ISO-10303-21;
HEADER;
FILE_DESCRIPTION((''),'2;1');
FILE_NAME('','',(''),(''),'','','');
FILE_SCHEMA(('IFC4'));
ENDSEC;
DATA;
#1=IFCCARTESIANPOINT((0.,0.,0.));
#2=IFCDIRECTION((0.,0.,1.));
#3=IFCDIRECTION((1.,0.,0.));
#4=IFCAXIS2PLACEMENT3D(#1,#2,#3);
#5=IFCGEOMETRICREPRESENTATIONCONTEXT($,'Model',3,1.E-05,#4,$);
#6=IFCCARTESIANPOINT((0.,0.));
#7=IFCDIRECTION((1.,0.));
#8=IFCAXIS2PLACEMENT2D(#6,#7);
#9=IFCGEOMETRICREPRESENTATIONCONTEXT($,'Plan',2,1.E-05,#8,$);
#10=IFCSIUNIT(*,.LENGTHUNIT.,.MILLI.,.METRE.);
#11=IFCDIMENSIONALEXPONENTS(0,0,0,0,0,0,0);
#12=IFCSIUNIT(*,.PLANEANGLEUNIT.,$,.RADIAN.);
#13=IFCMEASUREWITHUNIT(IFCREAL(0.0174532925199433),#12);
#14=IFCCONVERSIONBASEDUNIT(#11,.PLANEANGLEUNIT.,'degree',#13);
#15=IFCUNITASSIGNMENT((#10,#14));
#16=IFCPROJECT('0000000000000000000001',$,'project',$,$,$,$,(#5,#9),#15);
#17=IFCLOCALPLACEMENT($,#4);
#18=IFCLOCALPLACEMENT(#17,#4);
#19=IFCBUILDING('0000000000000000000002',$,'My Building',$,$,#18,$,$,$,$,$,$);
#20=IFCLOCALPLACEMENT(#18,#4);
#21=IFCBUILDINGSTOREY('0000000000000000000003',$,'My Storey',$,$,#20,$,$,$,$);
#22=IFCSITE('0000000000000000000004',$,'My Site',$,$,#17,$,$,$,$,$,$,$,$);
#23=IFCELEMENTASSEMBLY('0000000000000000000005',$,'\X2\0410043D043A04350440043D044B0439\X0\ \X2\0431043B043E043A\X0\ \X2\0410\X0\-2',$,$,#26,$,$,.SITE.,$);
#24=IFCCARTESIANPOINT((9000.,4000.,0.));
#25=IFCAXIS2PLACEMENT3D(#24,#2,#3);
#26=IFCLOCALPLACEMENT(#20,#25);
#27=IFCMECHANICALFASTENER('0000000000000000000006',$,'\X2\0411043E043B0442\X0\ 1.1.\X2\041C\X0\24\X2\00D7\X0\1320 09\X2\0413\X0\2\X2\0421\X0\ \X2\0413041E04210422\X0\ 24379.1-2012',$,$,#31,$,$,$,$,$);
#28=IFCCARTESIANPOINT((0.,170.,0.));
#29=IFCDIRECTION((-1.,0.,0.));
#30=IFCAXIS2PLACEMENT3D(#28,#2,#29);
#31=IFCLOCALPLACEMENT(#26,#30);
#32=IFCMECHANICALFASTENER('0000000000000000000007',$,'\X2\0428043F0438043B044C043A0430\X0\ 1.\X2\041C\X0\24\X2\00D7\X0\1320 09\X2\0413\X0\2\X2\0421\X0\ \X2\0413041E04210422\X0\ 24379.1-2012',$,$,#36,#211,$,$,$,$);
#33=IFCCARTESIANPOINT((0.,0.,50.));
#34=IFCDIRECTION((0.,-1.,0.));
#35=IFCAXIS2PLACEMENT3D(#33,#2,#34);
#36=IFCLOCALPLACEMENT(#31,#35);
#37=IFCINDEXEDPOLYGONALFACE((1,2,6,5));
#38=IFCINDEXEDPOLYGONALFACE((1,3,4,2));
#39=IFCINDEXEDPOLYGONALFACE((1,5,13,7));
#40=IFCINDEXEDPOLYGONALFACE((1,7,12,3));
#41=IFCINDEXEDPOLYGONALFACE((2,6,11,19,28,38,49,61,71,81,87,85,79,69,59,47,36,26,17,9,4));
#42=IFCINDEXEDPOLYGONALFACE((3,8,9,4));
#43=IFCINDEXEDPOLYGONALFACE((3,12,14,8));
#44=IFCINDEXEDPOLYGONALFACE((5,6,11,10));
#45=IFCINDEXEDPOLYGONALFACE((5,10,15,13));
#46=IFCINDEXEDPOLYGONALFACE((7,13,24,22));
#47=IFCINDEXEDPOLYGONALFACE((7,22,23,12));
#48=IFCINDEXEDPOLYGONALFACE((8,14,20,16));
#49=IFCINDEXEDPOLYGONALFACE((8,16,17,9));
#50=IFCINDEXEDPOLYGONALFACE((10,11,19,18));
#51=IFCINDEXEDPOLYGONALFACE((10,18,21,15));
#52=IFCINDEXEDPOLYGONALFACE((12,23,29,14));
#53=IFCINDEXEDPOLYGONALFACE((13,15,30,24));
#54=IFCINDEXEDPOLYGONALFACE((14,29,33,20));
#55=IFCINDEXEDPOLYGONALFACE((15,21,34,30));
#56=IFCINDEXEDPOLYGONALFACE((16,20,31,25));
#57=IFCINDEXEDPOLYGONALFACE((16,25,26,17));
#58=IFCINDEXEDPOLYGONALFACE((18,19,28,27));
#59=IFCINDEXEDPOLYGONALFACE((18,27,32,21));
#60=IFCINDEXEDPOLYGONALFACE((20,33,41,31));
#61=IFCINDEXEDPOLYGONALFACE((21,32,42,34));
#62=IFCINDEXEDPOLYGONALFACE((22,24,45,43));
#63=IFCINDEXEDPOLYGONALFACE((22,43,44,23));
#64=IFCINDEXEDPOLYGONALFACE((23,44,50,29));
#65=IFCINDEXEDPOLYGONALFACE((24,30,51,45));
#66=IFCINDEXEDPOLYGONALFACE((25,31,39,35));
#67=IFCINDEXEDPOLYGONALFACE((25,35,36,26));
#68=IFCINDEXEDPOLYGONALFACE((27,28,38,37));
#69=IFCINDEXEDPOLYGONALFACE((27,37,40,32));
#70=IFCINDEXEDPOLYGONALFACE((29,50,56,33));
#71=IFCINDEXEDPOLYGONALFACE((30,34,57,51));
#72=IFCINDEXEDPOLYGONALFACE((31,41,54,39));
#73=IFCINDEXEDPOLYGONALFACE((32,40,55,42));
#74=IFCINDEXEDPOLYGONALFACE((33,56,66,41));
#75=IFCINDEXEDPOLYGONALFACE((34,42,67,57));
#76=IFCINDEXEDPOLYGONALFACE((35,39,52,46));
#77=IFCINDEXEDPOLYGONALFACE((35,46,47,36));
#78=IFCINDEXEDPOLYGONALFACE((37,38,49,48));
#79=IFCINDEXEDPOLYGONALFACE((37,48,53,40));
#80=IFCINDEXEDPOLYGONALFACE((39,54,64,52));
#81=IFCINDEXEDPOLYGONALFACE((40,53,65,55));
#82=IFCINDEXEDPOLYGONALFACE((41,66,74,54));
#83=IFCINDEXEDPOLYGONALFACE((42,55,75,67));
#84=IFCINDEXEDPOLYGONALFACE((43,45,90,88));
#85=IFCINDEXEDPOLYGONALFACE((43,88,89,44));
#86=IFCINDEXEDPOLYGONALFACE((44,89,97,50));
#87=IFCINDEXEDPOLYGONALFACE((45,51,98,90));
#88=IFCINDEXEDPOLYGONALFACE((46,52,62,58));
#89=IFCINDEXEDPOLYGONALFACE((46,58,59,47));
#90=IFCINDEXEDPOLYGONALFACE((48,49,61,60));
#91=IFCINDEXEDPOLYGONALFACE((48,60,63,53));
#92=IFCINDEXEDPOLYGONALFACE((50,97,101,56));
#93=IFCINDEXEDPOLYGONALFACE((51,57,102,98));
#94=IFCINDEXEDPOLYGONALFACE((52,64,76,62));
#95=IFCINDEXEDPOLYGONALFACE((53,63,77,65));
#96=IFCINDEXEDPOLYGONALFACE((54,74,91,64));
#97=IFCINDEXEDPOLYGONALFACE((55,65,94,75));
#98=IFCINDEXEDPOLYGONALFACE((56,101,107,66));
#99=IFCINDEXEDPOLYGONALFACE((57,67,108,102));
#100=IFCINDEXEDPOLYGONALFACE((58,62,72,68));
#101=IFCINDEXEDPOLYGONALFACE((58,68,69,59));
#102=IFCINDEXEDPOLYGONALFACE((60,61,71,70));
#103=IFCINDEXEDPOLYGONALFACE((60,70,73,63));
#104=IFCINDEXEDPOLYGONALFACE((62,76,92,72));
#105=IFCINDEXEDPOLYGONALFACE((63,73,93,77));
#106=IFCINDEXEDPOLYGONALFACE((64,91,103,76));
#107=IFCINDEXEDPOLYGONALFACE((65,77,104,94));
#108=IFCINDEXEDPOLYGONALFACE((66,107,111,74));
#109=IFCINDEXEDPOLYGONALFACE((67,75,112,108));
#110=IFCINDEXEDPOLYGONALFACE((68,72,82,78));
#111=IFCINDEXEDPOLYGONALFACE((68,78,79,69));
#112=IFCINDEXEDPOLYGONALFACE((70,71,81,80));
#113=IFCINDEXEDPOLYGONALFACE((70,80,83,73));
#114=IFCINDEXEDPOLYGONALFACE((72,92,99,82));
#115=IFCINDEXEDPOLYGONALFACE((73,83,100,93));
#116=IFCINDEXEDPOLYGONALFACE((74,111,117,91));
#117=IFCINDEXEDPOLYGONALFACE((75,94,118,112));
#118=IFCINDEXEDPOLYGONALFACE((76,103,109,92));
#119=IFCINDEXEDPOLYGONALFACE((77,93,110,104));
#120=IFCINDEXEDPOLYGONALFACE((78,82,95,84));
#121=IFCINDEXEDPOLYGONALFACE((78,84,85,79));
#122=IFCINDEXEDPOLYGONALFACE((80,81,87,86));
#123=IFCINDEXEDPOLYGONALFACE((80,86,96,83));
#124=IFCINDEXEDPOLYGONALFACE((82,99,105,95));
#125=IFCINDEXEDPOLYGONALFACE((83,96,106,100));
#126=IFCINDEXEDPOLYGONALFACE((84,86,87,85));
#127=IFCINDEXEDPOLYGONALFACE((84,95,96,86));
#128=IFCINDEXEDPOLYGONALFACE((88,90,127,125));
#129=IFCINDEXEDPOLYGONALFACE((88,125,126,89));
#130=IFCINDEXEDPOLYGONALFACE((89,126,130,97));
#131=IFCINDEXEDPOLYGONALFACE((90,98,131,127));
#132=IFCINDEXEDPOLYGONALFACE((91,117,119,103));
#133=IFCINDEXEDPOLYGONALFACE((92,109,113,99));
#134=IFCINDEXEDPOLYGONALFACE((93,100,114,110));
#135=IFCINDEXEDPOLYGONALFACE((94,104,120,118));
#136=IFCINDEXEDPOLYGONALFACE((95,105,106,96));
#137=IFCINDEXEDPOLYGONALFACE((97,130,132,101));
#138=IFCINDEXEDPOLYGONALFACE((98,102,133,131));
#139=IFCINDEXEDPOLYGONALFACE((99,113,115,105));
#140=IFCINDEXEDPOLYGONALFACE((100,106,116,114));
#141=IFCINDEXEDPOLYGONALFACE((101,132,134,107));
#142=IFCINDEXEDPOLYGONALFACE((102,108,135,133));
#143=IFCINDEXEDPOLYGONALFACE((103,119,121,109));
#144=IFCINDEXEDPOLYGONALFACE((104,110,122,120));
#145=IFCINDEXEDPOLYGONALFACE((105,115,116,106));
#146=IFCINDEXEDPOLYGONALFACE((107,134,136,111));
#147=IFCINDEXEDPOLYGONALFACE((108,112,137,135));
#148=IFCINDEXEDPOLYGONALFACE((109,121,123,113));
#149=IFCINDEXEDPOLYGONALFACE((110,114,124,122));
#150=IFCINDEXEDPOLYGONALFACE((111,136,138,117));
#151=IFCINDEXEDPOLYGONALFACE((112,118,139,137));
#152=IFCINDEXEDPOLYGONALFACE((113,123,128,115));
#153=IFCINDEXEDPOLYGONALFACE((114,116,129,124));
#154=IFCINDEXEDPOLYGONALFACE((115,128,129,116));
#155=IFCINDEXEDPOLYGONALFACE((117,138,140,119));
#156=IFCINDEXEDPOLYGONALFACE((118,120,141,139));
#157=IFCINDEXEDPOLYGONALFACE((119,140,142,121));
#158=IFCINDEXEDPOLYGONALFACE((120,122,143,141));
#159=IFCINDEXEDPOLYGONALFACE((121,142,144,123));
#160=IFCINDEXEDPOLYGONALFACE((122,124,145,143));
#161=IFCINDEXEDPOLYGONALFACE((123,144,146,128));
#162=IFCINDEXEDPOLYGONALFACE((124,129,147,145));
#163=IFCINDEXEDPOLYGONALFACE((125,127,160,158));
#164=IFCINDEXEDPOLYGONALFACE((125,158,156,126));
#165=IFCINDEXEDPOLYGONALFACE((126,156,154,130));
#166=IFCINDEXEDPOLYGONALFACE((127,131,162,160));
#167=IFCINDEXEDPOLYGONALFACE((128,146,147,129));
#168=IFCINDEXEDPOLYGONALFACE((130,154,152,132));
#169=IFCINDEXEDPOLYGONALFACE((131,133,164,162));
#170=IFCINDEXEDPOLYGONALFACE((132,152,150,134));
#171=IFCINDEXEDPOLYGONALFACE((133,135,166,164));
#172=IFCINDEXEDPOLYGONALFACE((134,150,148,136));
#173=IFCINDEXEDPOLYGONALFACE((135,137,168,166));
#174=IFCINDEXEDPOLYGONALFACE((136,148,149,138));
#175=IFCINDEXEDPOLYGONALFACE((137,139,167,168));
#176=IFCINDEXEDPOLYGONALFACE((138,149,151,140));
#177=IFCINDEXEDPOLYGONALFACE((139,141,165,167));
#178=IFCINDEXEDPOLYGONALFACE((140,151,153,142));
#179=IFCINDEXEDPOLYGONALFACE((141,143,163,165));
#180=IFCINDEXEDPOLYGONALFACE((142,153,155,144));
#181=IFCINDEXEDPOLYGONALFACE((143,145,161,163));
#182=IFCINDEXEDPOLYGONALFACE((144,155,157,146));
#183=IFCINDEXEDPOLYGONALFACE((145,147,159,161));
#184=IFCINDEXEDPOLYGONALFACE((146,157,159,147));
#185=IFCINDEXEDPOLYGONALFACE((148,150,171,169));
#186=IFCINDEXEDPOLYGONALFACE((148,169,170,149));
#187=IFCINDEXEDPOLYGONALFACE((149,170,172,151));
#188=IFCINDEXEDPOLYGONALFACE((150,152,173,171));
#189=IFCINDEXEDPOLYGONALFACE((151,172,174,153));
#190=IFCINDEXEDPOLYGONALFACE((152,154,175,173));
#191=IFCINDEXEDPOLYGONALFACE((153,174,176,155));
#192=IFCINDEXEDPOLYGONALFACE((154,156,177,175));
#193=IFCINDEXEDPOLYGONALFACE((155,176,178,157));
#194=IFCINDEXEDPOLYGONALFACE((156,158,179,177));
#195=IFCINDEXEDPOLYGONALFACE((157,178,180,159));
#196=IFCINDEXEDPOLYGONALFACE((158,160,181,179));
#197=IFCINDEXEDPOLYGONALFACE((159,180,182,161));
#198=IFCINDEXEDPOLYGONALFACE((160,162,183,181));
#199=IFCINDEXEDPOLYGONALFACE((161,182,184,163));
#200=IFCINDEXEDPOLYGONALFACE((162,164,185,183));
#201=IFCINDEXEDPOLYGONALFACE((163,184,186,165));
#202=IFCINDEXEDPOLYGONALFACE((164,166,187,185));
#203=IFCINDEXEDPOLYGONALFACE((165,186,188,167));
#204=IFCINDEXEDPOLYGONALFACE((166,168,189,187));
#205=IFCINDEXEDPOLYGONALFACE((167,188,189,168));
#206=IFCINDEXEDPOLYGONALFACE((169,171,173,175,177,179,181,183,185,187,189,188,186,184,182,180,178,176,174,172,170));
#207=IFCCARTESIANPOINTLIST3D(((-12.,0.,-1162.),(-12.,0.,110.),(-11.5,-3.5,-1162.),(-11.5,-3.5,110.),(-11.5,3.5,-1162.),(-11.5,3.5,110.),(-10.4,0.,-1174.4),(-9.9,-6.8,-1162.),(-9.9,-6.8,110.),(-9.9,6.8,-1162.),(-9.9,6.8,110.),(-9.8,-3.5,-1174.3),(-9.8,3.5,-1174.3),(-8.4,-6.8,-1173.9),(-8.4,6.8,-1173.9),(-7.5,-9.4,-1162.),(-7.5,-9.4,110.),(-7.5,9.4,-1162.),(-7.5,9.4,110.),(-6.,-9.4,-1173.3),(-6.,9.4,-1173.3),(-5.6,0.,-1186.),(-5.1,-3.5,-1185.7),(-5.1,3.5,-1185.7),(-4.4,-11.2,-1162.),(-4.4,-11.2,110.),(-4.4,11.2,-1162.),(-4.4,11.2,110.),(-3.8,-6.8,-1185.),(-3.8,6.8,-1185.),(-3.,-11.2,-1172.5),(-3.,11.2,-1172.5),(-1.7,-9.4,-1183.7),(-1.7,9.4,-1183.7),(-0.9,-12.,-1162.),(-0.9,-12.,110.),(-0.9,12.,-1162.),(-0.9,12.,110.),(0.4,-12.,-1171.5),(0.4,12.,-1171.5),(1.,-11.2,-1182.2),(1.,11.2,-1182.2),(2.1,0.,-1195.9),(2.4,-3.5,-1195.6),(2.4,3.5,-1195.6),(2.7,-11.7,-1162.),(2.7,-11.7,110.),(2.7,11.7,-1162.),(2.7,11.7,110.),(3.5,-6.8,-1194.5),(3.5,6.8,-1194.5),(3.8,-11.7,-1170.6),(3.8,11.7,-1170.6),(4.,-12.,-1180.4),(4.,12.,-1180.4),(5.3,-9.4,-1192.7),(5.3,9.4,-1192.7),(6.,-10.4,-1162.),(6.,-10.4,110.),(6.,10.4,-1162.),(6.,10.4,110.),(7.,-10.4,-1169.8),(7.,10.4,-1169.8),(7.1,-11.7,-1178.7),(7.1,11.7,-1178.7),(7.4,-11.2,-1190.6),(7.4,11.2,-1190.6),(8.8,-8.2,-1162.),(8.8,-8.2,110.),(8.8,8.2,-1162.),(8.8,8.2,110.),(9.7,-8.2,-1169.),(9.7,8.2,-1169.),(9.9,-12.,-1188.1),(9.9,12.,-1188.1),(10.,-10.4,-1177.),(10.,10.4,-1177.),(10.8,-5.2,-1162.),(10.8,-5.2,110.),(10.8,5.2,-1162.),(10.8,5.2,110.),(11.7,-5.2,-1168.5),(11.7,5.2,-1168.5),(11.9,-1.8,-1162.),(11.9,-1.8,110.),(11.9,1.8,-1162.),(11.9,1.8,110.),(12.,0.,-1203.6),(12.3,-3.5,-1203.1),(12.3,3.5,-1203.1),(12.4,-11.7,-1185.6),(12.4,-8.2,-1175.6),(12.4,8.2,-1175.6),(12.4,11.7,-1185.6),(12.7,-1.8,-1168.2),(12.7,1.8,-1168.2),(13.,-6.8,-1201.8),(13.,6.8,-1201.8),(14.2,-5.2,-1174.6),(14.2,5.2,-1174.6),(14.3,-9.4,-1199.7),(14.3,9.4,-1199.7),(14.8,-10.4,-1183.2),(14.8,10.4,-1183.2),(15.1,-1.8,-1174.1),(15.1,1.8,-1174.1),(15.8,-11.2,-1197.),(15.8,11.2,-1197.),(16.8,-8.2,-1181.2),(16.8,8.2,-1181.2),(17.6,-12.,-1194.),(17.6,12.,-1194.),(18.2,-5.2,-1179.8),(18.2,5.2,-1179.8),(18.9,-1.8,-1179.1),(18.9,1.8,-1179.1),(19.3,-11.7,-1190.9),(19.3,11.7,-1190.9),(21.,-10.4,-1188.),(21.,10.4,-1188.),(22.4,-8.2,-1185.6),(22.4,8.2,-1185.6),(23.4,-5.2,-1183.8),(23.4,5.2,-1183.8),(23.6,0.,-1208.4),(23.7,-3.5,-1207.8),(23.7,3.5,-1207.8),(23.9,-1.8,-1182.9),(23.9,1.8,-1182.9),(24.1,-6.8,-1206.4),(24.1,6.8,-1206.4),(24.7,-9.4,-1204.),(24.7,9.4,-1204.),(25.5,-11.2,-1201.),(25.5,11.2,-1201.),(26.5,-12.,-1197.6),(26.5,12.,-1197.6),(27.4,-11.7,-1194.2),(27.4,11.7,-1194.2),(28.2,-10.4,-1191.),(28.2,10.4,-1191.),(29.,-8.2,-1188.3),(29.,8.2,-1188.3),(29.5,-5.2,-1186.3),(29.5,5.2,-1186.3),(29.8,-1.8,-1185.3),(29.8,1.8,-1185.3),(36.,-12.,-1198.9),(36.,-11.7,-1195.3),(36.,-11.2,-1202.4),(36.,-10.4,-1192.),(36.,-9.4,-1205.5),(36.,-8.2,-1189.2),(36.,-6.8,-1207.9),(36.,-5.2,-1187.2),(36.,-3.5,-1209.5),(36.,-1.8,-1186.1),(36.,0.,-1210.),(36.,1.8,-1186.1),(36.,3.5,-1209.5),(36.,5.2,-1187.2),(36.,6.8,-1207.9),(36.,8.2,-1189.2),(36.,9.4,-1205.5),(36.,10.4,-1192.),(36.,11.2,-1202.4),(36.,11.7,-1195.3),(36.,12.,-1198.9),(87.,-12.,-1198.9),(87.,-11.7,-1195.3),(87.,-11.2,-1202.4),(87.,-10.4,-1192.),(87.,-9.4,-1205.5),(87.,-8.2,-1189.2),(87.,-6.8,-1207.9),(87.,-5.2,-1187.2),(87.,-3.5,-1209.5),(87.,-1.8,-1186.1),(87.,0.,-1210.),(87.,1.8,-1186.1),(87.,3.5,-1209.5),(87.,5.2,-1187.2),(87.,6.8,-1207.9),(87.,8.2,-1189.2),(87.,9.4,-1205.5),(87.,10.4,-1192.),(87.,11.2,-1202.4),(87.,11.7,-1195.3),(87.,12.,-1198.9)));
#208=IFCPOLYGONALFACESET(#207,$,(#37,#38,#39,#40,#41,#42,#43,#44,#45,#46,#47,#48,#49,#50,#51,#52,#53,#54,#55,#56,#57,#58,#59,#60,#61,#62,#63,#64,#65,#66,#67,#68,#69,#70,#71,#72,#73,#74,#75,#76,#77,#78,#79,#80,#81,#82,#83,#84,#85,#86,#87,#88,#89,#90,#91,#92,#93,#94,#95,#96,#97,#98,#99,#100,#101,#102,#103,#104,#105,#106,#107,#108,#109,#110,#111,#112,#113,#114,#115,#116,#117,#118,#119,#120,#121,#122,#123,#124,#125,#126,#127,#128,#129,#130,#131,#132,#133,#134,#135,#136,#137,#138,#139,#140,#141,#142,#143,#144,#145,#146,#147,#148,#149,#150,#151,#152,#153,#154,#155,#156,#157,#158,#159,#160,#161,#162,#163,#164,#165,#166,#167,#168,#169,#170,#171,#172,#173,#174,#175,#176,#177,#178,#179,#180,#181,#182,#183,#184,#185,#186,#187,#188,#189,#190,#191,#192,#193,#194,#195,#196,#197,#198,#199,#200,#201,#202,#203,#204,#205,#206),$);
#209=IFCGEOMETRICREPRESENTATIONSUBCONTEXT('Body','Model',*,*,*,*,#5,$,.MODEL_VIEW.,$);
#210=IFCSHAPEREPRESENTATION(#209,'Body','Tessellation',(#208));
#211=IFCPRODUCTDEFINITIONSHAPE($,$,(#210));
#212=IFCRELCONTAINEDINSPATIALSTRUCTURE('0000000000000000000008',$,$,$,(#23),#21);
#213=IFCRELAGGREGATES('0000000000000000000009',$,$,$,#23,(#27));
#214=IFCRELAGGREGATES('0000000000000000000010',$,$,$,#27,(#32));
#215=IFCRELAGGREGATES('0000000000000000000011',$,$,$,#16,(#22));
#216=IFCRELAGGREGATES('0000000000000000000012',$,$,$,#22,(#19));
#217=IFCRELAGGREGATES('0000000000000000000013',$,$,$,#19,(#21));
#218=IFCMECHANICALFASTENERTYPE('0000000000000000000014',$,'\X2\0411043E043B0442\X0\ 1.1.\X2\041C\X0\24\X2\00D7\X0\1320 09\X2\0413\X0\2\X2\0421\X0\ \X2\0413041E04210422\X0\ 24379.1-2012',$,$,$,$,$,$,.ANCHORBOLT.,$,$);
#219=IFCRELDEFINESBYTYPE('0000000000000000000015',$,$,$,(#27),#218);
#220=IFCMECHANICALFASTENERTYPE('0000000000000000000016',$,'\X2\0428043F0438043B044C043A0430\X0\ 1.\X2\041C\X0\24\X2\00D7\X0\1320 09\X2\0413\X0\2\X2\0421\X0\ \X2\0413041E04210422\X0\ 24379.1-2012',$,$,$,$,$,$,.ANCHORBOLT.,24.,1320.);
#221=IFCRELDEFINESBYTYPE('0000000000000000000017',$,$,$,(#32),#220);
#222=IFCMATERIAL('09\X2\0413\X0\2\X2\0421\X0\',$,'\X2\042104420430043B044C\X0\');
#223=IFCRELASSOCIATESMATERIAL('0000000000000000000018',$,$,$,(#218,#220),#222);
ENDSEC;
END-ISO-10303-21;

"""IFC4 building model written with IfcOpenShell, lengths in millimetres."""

from ifc_helpers import new_model, entity, si_unit, converted_unit, frame, origin_with_axes, origin_2d_with_axis, place, context, subcontext, project, spatial, source, transform, mapped, material, type_object, type_shapes, element, aggregate, save


model = new_model("IFC4")

# Units and contexts
model_context = context("Model", 3, precision=1e-05, world=origin_with_axes())
plan_context = context("Plan", 2, precision=1e-05, world=origin_2d_with_axis())
body_context = subcontext(model_context, "Body", "Model", "MODEL_VIEW")
ifc_project = project(units=[si_unit("LENGTHUNIT", "METRE", prefix="MILLI"), converted_unit("PLANEANGLEUNIT", "degree", entity("IfcReal", 0.0174532925199433), si_unit("PLANEANGLEUNIT", "RADIAN"), dimensions=[0, 0, 0, 0, 0, 0, 0])], contexts=[model_context, plan_context])

# Site, building, storey
site_placement = place(None, origin_with_axes())
site = spatial("IfcSite", under=ifc_project, at=site_placement, Name="My Site")
building_placement = place(site_placement, origin_with_axes())
building = spatial("IfcBuilding", under=site, at=building_placement, Name="My Building")
storey_placement = place(building_placement, origin_with_axes())
storey = spatial("IfcBuildingStorey", under=building, at=storey_placement, Name="My Storey")

# Element assembly, mechanical fasteners
ifc_material_1 = material(Name="09Г2С", Category="Сталь")
mechanical_fastener_type_1 = type_object("IfcMechanicalFastenerType", Name="Болт 1.1.М24×1320 09Г2С ГОСТ 24379.1-2012", PredefinedType="ANCHORBOLT", material=ifc_material_1)
mechanical_fastener_type_2 = type_object("IfcMechanicalFastenerType", Name="Шпилька 1.М24×1320 09Г2С ГОСТ 24379.1-2012", NominalDiameter=24.0, NominalLength=1320.0, PredefinedType="ANCHORBOLT", material=ifc_material_1)
shared_shape_1 = source(frame((0.0, 0.0, 110.0), z_axis=(0.0, 0.0, 1.0), x_axis=(1.0, 0.0, 0.0)), body_context, "Body", "AdvancedSweptSolid", [
    entity("IfcSweptDiskSolid", entity("IfcIndexedPolyCurve", entity("IfcCartesianPointList3D", [[0.0, 0.0, 0.0], [0.0, 0.0, -1272.0], [10.5, 0.0, -1297.5], [36.0, 0.0, -1308.0], [87.0, 0.0, -1308.0]]), [entity("IfcLineIndex", [1, 2]), entity("IfcArcIndex", [2, 3, 4]), entity("IfcLineIndex", [4, 5])]), 12.0),
])
type_shapes(mechanical_fastener_type_2, [shared_shape_1])
assembly_1_placement = place(storey_placement, frame((9000.0, 4000.0, 0.0), z_axis=(0.0, 0.0, 1.0), x_axis=(1.0, 0.0, 0.0)))
assembly_1 = element("IfcElementAssembly", 1, at=assembly_1_placement, inside=storey, Name="Анкерный блок А-2", AssemblyPlace="SITE")
mechanical_fastener_1_placement = place(assembly_1_placement, frame((0.0, 170.0, 0.0), z_axis=(0.0, 0.0, 1.0), x_axis=(-1.0, 0.0, 0.0)))
mechanical_fastener_1 = element("IfcMechanicalFastener", 2, at=mechanical_fastener_1_placement, type_object=mechanical_fastener_type_1, Name="Болт 1.1.М24×1320 09Г2С ГОСТ 24379.1-2012")
aggregate(assembly_1, [mechanical_fastener_1])
mechanical_fastener_2_placement = place(mechanical_fastener_1_placement, frame((0.0, 0.0, 50.0), z_axis=(0.0, 0.0, 1.0), x_axis=(0.0, -1.0, 0.0)))
mechanical_fastener_2 = element("IfcMechanicalFastener", 3, at=mechanical_fastener_2_placement, type_object=mechanical_fastener_type_2, Name="Шпилька 1.М24×1320 09Г2С ГОСТ 24379.1-2012", context=body_context, shape_type="MappedRepresentation", body=[
    mapped(shared_shape_1, transform((0.0, 0.0, 0.0), x_axis=(1.0, 0.0, 0.0), y_axis=(0.0, 1.0, 0.0), z_axis=(0.0, 0.0, 1.0), scale=1.0)),
])

aggregate(mechanical_fastener_1, [mechanical_fastener_2])

save(model, "model.ifc")
